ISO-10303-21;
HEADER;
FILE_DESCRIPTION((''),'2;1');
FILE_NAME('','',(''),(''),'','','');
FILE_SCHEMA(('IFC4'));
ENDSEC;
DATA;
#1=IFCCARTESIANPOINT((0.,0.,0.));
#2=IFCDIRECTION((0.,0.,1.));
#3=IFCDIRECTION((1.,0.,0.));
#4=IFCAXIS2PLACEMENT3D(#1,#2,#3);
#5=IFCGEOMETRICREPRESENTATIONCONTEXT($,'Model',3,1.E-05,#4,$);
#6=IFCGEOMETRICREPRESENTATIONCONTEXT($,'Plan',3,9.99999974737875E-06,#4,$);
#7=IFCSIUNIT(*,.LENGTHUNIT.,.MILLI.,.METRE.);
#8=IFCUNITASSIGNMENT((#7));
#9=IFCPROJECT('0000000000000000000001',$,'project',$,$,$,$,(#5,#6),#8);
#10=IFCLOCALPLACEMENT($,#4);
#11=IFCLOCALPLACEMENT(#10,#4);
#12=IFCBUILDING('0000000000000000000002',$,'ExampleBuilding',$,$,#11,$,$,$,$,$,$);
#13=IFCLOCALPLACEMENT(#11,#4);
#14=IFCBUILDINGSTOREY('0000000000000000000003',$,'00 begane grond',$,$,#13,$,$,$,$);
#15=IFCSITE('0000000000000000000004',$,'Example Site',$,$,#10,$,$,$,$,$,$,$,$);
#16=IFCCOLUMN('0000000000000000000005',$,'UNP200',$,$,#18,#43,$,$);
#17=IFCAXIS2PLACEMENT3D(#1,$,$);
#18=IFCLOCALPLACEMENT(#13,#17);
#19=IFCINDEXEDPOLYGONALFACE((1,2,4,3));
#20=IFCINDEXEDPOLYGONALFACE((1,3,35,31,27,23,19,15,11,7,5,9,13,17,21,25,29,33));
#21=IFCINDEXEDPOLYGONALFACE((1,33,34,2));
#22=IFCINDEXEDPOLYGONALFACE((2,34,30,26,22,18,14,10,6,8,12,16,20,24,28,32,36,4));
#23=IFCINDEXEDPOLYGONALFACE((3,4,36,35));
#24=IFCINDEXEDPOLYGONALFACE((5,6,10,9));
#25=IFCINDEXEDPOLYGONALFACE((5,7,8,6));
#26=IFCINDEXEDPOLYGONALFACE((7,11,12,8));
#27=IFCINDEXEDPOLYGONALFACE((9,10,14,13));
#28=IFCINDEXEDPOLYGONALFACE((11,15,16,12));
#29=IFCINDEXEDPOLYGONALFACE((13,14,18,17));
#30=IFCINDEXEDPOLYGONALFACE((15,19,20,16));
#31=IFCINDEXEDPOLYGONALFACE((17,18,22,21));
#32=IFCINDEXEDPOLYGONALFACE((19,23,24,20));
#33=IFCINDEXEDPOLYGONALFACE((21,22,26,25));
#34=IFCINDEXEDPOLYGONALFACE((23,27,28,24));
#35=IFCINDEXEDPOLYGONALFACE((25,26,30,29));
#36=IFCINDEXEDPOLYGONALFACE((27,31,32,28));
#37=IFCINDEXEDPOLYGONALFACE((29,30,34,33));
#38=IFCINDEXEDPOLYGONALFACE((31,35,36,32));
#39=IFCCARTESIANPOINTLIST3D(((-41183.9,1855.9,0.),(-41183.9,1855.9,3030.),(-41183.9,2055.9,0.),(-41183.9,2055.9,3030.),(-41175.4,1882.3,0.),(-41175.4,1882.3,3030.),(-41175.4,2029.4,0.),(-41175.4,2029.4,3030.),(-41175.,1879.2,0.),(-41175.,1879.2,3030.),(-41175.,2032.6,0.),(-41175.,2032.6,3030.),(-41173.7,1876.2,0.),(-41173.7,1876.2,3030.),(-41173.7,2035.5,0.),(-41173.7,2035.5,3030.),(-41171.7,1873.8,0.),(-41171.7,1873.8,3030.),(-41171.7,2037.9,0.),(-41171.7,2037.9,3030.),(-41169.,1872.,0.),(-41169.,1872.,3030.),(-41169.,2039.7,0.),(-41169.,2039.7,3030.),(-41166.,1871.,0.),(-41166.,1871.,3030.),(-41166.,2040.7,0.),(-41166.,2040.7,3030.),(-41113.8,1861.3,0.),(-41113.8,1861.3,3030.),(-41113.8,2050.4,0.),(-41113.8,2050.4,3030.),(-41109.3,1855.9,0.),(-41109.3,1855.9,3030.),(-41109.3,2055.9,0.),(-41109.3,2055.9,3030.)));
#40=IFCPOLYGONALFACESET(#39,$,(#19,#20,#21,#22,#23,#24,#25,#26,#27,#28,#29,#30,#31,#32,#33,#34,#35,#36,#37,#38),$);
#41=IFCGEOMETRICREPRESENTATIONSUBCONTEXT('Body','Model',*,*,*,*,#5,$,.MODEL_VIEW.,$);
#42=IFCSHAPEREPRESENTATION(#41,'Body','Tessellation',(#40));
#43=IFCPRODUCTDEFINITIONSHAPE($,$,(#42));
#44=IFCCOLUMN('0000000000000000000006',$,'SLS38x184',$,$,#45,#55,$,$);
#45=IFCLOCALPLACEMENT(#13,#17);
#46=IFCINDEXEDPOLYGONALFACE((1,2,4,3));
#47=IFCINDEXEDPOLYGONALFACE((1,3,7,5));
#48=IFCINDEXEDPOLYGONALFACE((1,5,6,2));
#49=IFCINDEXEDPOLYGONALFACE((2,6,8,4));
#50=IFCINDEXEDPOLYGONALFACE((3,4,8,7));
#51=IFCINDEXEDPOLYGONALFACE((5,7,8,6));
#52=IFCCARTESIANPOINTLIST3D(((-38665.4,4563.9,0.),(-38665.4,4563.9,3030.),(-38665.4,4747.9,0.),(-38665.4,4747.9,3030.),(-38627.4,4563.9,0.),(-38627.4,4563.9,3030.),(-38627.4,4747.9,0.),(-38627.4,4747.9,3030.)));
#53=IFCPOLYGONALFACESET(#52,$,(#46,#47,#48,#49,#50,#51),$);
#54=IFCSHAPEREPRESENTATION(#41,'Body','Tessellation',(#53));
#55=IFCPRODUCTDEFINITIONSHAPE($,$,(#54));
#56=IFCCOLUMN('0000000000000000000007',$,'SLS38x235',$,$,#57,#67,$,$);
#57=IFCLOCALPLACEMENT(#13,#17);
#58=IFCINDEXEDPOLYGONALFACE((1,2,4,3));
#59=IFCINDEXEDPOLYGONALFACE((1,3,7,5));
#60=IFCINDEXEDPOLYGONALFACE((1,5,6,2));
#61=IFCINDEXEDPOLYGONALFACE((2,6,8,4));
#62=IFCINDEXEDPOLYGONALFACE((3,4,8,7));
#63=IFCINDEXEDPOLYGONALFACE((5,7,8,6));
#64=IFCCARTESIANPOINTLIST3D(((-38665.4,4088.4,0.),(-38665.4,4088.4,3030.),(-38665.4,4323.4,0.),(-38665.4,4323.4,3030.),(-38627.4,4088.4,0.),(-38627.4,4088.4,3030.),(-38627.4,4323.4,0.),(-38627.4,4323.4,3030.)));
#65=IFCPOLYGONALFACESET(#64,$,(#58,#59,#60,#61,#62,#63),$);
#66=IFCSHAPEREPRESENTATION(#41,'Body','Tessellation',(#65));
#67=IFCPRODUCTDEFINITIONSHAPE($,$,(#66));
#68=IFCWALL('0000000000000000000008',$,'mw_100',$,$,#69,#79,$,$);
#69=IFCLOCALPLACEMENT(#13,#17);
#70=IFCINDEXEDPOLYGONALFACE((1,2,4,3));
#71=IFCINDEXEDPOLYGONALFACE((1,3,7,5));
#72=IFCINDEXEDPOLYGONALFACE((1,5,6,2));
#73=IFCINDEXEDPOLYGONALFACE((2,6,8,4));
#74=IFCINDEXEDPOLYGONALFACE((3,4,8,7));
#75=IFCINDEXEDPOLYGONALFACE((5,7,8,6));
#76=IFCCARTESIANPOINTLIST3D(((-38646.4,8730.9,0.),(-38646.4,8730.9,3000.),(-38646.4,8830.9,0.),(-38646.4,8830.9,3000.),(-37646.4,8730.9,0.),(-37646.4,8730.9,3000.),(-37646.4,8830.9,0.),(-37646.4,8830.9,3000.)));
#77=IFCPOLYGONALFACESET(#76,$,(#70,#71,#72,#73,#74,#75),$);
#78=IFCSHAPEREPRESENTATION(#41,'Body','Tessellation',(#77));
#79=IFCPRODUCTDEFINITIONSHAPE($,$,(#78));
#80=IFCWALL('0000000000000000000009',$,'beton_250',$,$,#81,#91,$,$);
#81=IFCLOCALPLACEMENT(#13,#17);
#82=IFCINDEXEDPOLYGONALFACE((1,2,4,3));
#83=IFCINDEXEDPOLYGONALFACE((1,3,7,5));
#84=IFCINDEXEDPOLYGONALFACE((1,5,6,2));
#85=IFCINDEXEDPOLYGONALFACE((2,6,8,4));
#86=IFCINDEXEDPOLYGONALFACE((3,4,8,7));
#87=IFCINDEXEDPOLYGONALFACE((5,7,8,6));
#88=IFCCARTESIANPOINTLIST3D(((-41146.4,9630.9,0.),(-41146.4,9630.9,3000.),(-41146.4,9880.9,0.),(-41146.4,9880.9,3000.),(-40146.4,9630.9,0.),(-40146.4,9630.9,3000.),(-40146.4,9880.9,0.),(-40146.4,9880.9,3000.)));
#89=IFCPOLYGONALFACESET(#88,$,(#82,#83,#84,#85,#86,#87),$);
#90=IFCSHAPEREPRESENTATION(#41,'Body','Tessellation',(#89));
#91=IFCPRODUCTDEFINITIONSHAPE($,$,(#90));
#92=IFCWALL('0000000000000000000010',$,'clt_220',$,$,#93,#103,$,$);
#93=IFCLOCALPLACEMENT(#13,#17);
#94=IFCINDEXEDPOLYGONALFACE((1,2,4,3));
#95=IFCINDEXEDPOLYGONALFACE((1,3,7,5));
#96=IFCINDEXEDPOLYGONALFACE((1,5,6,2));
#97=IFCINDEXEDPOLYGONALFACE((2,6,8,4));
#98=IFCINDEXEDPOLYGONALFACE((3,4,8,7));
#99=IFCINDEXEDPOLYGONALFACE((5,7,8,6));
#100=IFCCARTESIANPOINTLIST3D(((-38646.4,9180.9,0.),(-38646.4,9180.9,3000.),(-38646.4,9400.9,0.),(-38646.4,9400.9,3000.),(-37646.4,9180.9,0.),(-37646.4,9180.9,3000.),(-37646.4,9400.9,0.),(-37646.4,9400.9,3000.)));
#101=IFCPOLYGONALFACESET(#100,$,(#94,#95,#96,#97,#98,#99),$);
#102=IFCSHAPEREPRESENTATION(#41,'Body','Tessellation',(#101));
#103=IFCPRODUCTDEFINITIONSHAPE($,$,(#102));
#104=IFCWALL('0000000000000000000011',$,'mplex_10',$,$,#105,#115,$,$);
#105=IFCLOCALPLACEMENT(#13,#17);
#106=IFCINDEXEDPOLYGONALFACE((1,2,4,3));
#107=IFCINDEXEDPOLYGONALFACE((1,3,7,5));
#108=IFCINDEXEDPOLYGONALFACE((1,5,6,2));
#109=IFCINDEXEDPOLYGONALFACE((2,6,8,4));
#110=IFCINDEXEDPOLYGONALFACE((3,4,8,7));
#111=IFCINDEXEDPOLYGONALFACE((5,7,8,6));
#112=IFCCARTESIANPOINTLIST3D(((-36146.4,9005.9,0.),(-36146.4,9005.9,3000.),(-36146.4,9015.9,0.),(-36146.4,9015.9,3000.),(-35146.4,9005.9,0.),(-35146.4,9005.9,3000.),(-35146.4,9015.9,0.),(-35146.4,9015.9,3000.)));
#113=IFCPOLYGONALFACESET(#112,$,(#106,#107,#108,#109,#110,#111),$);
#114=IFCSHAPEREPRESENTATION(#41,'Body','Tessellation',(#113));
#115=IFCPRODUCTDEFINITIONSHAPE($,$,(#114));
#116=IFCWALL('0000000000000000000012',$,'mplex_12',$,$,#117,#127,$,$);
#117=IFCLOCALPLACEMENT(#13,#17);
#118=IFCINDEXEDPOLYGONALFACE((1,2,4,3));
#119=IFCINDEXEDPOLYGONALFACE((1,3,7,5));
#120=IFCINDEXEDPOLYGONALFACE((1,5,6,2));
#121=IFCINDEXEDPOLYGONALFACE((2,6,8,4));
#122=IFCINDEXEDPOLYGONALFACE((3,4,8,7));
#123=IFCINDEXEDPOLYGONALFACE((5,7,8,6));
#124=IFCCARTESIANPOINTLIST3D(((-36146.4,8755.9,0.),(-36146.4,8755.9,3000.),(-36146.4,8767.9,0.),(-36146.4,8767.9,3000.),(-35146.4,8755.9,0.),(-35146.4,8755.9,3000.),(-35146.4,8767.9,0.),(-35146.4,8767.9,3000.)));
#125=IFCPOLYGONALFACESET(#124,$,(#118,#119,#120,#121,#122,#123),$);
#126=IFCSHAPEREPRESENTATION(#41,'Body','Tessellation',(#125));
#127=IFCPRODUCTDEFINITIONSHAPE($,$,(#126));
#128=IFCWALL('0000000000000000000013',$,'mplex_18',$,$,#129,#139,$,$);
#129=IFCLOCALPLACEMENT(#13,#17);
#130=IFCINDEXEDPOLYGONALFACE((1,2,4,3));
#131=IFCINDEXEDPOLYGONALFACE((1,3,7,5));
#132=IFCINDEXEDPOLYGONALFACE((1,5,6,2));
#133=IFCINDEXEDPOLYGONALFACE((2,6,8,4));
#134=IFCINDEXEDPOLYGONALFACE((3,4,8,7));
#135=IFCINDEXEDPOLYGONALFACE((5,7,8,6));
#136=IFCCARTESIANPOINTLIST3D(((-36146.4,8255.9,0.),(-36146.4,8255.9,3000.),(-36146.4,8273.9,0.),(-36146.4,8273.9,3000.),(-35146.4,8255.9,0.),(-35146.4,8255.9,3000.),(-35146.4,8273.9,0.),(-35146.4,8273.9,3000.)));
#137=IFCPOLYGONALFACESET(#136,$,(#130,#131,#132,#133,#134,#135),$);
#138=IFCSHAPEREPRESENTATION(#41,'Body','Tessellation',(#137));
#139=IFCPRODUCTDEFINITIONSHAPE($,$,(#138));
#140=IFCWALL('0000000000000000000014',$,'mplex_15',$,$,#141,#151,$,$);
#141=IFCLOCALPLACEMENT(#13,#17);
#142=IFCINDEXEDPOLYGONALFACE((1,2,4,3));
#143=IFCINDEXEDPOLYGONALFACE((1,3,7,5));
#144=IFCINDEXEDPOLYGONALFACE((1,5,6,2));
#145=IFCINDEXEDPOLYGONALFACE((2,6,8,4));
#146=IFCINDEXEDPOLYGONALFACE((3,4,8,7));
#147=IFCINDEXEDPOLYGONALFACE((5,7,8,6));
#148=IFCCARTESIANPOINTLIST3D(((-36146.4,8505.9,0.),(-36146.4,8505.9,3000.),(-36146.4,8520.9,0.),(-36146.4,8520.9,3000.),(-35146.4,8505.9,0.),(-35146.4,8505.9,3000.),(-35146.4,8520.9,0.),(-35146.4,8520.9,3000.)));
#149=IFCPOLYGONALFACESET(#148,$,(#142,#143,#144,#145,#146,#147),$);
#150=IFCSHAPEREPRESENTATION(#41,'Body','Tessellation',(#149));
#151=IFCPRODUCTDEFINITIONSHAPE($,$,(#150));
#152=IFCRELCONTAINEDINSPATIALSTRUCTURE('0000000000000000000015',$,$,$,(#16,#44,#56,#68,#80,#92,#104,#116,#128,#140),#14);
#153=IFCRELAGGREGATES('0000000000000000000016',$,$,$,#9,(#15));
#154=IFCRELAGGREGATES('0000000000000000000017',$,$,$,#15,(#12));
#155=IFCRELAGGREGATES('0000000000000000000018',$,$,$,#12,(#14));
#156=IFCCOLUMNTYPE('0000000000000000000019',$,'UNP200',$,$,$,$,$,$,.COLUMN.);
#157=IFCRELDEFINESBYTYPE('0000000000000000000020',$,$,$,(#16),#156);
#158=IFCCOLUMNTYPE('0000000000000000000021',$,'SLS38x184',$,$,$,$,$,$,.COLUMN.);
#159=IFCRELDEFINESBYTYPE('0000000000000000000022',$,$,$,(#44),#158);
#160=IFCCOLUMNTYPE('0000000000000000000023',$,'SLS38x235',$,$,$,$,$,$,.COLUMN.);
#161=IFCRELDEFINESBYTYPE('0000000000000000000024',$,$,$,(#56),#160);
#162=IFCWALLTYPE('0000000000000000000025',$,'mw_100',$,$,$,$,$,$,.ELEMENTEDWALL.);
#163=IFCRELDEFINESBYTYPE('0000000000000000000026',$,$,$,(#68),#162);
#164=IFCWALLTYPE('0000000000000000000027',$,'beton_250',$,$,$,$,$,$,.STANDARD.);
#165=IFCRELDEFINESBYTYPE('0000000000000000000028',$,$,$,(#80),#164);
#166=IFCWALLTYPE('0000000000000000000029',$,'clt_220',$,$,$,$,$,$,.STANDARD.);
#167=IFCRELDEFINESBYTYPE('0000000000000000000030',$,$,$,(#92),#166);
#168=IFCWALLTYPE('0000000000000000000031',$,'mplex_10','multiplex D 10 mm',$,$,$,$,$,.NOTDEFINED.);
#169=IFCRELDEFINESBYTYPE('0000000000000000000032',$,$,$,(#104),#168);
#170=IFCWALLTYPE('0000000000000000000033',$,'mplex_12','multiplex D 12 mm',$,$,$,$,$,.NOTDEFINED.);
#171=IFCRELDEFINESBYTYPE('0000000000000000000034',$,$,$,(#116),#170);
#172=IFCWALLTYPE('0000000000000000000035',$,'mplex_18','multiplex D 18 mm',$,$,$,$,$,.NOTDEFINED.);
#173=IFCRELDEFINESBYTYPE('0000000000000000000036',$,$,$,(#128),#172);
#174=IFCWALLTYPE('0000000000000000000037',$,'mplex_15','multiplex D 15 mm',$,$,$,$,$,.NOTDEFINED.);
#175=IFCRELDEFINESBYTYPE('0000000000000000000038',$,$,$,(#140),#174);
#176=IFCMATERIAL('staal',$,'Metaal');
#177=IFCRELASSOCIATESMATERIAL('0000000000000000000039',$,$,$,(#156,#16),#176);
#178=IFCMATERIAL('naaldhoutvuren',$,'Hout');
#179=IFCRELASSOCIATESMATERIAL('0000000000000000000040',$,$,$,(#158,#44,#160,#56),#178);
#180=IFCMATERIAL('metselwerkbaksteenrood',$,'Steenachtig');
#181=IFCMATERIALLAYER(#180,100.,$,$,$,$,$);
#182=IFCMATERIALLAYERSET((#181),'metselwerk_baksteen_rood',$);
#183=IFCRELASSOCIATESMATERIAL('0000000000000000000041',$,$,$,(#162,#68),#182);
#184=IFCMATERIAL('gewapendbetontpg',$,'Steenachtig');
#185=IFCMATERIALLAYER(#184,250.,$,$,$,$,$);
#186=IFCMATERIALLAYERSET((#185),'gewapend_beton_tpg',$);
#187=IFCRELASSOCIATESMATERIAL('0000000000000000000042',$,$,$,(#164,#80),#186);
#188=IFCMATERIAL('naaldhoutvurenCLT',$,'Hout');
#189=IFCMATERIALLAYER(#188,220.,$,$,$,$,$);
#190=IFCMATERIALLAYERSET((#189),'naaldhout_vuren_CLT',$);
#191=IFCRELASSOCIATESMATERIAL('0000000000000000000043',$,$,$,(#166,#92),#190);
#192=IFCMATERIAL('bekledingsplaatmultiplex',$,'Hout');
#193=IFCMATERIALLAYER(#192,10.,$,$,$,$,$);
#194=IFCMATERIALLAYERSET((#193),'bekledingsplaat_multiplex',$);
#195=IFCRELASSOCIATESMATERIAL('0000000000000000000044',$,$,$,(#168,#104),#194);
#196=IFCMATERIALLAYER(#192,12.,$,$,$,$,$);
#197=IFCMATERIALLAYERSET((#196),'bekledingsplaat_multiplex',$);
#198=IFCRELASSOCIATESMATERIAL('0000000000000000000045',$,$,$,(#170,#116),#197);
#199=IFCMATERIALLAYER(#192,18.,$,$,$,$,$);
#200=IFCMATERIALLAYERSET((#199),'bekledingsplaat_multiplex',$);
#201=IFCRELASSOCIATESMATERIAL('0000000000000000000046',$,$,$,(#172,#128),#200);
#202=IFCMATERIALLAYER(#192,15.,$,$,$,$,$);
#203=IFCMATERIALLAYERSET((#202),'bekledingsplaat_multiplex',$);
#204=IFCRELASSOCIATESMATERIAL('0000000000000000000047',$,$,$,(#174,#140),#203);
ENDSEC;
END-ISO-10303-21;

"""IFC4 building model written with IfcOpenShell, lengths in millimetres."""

from ifc_helpers import new_model, si_unit, frame, origin_with_axes, place, context, subcontext, project, spatial, indexed_curve, rectangle, u_section, outline, extrude, material, layer, layer_set, layer_usage, material_profile, profile_set, profile_usage, type_object, element, save


model = new_model("IFC4")

# Units and contexts
model_context = context("Model", 3, precision=1e-05, world=origin_with_axes())
plan_context = context("Plan", 3, precision=9.99999974737875e-06, world=origin_with_axes())
body_context = subcontext(model_context, "Body", "Model", "MODEL_VIEW")
ifc_project = project(units=[si_unit("LENGTHUNIT", "METRE", prefix="MILLI")], contexts=[model_context, plan_context])

# Site, building, storey
site_placement = place(None, frame((0.0, 0.0, 0.0), z_axis=(0.0, 0.0, 1.0), x_axis=(1.0, 0.0, 0.0)))
site = spatial("IfcSite", under=ifc_project, at=site_placement, Name="Example Site")
building_placement = place(site_placement, frame((0.0, 0.0, 0.0), z_axis=(0.0, 0.0, 1.0), x_axis=(1.0, 0.0, 0.0)))
building = spatial("IfcBuilding", under=site, at=building_placement, Name="ExampleBuilding")
storey_placement = place(building_placement, frame((0.0, 0.0, 0.0), z_axis=(0.0, 0.0, 1.0), x_axis=(1.0, 0.0, 0.0)))
storey = spatial("IfcBuildingStorey", under=building, at=storey_placement, Name="00 begane grond")

# Columns
ifc_material_1 = material(Name="staal", Category="Metaal")
ifc_material_2 = material(Name="gewapendbetontpg", Category="Steenachtig")
ifc_material_3 = material(Name="naaldhoutvuren", Category="Hout")
ifc_material_profile_1 = material_profile(ifc_material_1, u_section(Depth=200.0, FlangeWidth=75.0, WebThickness=8.5, FlangeThickness=11.5, FilletRadius=11.5, EdgeRadius=6.0, FlangeSlope=6.1, kind="CURVE"))
ifc_profile_set_1 = profile_set([ifc_material_profile_1], Name="staal")
ifc_profile_usage_1 = profile_usage(ifc_profile_set_1)
column_type_1 = type_object("IfcColumnType", Name="UNP200", PredefinedType="COLUMN", material=ifc_profile_set_1)
column_1_placement = place(storey_placement, frame((-41146.4, 1955.9, 0.0), z_axis=(0.0, 0.0, 1.0), x_axis=(1.0, 0.0, 0.0)))
element("IfcColumn", 1, at=column_1_placement, inside=storey, type_object=column_type_1, material=ifc_profile_usage_1, Name="UNP200", context=body_context, shape_type="SweptSolid", body=[
    extrude(u_section(Depth=200.0, FlangeWidth=75.0, WebThickness=8.5, FlangeThickness=11.5, FilletRadius=11.5, EdgeRadius=6.0, FlangeSlope=6.1, kind="CURVE"), origin_with_axes(), (0.0, 0.0, 1.0), 3030.0),
])
ifc_material_profile_2 = material_profile(ifc_material_3, rectangle(XDim=38.0, YDim=184.0, kind="CURVE"))
ifc_profile_set_2 = profile_set([ifc_material_profile_2], Name="naaldhoutvuren")
ifc_profile_usage_2 = profile_usage(ifc_profile_set_2)
column_type_2 = type_object("IfcColumnType", Name="SLS38x184", PredefinedType="COLUMN", material=ifc_profile_set_2)
column_2_placement = place(storey_placement, frame((-38646.4, 4655.9, 0.0), z_axis=(0.0, 0.0, 1.0), x_axis=(1.0, 0.0, 0.0)))
element("IfcColumn", 2, at=column_2_placement, inside=storey, type_object=column_type_2, material=ifc_profile_usage_2, Name="SLS38x184", context=body_context, shape_type="SweptSolid", body=[
    extrude(rectangle(XDim=38.0, YDim=184.0, kind="CURVE"), origin_with_axes(), (0.0, 0.0, 1.0), 3030.0),
])
ifc_material_profile_3 = material_profile(ifc_material_3, rectangle(XDim=38.0, YDim=235.0, kind="CURVE"))
ifc_profile_set_3 = profile_set([ifc_material_profile_3], Name="naaldhoutvuren")
ifc_profile_usage_3 = profile_usage(ifc_profile_set_3)
column_type_3 = type_object("IfcColumnType", Name="SLS38x235", PredefinedType="COLUMN", material=ifc_profile_set_3)
column_3_placement = place(storey_placement, frame((-38646.4, 4205.9, 0.0), z_axis=(0.0, 0.0, 1.0), x_axis=(1.0, 0.0, 0.0)))
element("IfcColumn", 3, at=column_3_placement, inside=storey, type_object=column_type_3, material=ifc_profile_usage_3, Name="SLS38x235", context=body_context, shape_type="SweptSolid", body=[
    extrude(rectangle(XDim=38.0, YDim=235.0, kind="CURVE"), origin_with_axes(), (0.0, 0.0, 1.0), 3030.0),
])

# Walls
ifc_material_4 = material(Name="metselwerkbaksteenrood", Category="Steenachtig")
ifc_layer_1 = layer(ifc_material_4, 100.0)
ifc_layer_set_1 = layer_set([ifc_layer_1], Name="metselwerk_baksteen_rood")
ifc_layer_usage_1 = layer_usage(ifc_layer_set_1, "AXIS2", "POSITIVE", 0.0)
wall_type_1 = type_object("IfcWallType", Name="mw_100", PredefinedType="ELEMENTEDWALL", material=ifc_layer_set_1)
wall_1_placement = place(storey_placement, frame((-38646.4, 8730.9, 0.0), z_axis=(0.0, 0.0, 1.0), x_axis=(1.0, 0.0, 0.0)))
element("IfcWall", 4, at=wall_1_placement, inside=storey, type_object=wall_type_1, material=ifc_layer_usage_1, Name="mw_100", context=body_context, shape_type="SweptSolid", body=[
    extrude(outline(indexed_curve([(0.0, 0.0), (0.0, 100.0), (1000.0, 100.0), (1000.0, 0.0), (0.0, 0.0)], self_intersect=False)), origin_with_axes(), (0.0, 0.0, 1.0), 3000.0),
])
ifc_layer_2 = layer(ifc_material_2, 250.0)
ifc_layer_set_2 = layer_set([ifc_layer_2], Name="gewapend_beton_tpg")
ifc_layer_usage_2 = layer_usage(ifc_layer_set_2, "AXIS2", "POSITIVE", 0.0)
wall_type_2 = type_object("IfcWallType", Name="beton_250", PredefinedType="STANDARD", material=ifc_layer_set_2)
wall_2_placement = place(storey_placement, frame((-41146.4, 9630.9, 0.0), z_axis=(0.0, 0.0, 1.0), x_axis=(1.0, 0.0, 0.0)))
element("IfcWall", 5, at=wall_2_placement, inside=storey, type_object=wall_type_2, material=ifc_layer_usage_2, Name="beton_250", context=body_context, shape_type="SweptSolid", body=[
    extrude(outline(indexed_curve([(0.0, 0.0), (0.0, 250.0), (1000.0, 250.0), (1000.0, 0.0), (0.0, 0.0)], self_intersect=False)), origin_with_axes(), (0.0, 0.0, 1.0), 3000.0),
])
ifc_material_5 = material(Name="naaldhoutvurenCLT", Category="Hout")
ifc_layer_3 = layer(ifc_material_5, 220.0)
ifc_layer_set_3 = layer_set([ifc_layer_3], Name="naaldhout_vuren_CLT")
ifc_layer_usage_3 = layer_usage(ifc_layer_set_3, "AXIS2", "POSITIVE", 0.0)
wall_type_3 = type_object("IfcWallType", Name="clt_220", PredefinedType="STANDARD", material=ifc_layer_set_3)
wall_3_placement = place(storey_placement, frame((-38646.4, 9180.9, 0.0), z_axis=(0.0, 0.0, 1.0), x_axis=(1.0, 0.0, 0.0)))
element("IfcWall", 6, at=wall_3_placement, inside=storey, type_object=wall_type_3, material=ifc_layer_usage_3, Name="clt_220", context=body_context, shape_type="SweptSolid", body=[
    extrude(outline(indexed_curve([(0.0, 0.0), (0.0, 220.0), (1000.0, 220.0), (1000.0, 0.0), (0.0, 0.0)], self_intersect=False)), origin_with_axes(), (0.0, 0.0, 1.0), 3000.0),
])
ifc_material_6 = material(Name="bekledingsplaatmultiplex", Category="Hout")
ifc_layer_4 = layer(ifc_material_6, 10.0)
ifc_layer_set_4 = layer_set([ifc_layer_4], Name="bekledingsplaat_multiplex")
ifc_layer_usage_4 = layer_usage(ifc_layer_set_4, "AXIS2", "POSITIVE", 0.0)
wall_type_4 = type_object("IfcWallType", Name="mplex_10", Description="multiplex D 10 mm", PredefinedType="NOTDEFINED", material=ifc_layer_set_4)
wall_4_placement = place(storey_placement, frame((-36146.4, 9005.9, 0.0), z_axis=(0.0, 0.0, 1.0), x_axis=(1.0, 0.0, 0.0)))
element("IfcWall", 7, at=wall_4_placement, inside=storey, type_object=wall_type_4, material=ifc_layer_usage_4, Name="mplex_10", context=body_context, shape_type="SweptSolid", body=[
    extrude(outline(indexed_curve([(0.0, 0.0), (0.0, 10.0), (1000.0, 10.0), (1000.0, 0.0), (0.0, 0.0)], self_intersect=False)), origin_with_axes(), (0.0, 0.0, 1.0), 3000.0),
])
ifc_layer_5 = layer(ifc_material_6, 12.0)
ifc_layer_set_5 = layer_set([ifc_layer_5], Name="bekledingsplaat_multiplex")
ifc_layer_usage_5 = layer_usage(ifc_layer_set_5, "AXIS2", "POSITIVE", 0.0)
wall_type_5 = type_object("IfcWallType", Name="mplex_12", Description="multiplex D 12 mm", PredefinedType="NOTDEFINED", material=ifc_layer_set_5)
wall_5_placement = place(storey_placement, frame((-36146.4, 8755.9, 0.0), z_axis=(0.0, 0.0, 1.0), x_axis=(1.0, 0.0, 0.0)))
element("IfcWall", 8, at=wall_5_placement, inside=storey, type_object=wall_type_5, material=ifc_layer_usage_5, Name="mplex_12", context=body_context, shape_type="SweptSolid", body=[
    extrude(outline(indexed_curve([(0.0, 0.0), (0.0, 12.0), (1000.0, 12.0), (1000.0, 0.0), (0.0, 0.0)], self_intersect=False)), origin_with_axes(), (0.0, 0.0, 1.0), 3000.0),
])
ifc_layer_6 = layer(ifc_material_6, 18.0)
ifc_layer_set_6 = layer_set([ifc_layer_6], Name="bekledingsplaat_multiplex")
ifc_layer_usage_6 = layer_usage(ifc_layer_set_6, "AXIS2", "POSITIVE", 0.0)
wall_type_6 = type_object("IfcWallType", Name="mplex_18", Description="multiplex D 18 mm", PredefinedType="NOTDEFINED", material=ifc_layer_set_6)
wall_6_placement = place(storey_placement, frame((-36146.4, 8255.9, 0.0), z_axis=(0.0, 0.0, 1.0), x_axis=(1.0, 0.0, 0.0)))
element("IfcWall", 9, at=wall_6_placement, inside=storey, type_object=wall_type_6, material=ifc_layer_usage_6, Name="mplex_18", context=body_context, shape_type="SweptSolid", body=[
    extrude(outline(indexed_curve([(0.0, 0.0), (0.0, 18.0), (1000.0, 18.0), (1000.0, 0.0), (0.0, 0.0)], self_intersect=False)), origin_with_axes(), (0.0, 0.0, 1.0), 3000.0),
])
ifc_layer_7 = layer(ifc_material_6, 15.0)
ifc_layer_set_7 = layer_set([ifc_layer_7], Name="bekledingsplaat_multiplex")
ifc_layer_usage_7 = layer_usage(ifc_layer_set_7, "AXIS2", "POSITIVE", 0.0)
wall_type_7 = type_object("IfcWallType", Name="mplex_15", Description="multiplex D 15 mm", PredefinedType="NOTDEFINED", material=ifc_layer_set_7)
wall_7_placement = place(storey_placement, frame((-36146.4, 8505.9, 0.0), z_axis=(0.0, 0.0, 1.0), x_axis=(1.0, 0.0, 0.0)))
element("IfcWall", 10, at=wall_7_placement, inside=storey, type_object=wall_type_7, material=ifc_layer_usage_7, Name="mplex_15", context=body_context, shape_type="SweptSolid", body=[
    extrude(outline(indexed_curve([(0.0, 0.0), (0.0, 15.0), (1000.0, 15.0), (1000.0, 0.0), (0.0, 0.0)], self_intersect=False)), origin_with_axes(), (0.0, 0.0, 1.0), 3000.0),
])

save(model, "model.ifc")
